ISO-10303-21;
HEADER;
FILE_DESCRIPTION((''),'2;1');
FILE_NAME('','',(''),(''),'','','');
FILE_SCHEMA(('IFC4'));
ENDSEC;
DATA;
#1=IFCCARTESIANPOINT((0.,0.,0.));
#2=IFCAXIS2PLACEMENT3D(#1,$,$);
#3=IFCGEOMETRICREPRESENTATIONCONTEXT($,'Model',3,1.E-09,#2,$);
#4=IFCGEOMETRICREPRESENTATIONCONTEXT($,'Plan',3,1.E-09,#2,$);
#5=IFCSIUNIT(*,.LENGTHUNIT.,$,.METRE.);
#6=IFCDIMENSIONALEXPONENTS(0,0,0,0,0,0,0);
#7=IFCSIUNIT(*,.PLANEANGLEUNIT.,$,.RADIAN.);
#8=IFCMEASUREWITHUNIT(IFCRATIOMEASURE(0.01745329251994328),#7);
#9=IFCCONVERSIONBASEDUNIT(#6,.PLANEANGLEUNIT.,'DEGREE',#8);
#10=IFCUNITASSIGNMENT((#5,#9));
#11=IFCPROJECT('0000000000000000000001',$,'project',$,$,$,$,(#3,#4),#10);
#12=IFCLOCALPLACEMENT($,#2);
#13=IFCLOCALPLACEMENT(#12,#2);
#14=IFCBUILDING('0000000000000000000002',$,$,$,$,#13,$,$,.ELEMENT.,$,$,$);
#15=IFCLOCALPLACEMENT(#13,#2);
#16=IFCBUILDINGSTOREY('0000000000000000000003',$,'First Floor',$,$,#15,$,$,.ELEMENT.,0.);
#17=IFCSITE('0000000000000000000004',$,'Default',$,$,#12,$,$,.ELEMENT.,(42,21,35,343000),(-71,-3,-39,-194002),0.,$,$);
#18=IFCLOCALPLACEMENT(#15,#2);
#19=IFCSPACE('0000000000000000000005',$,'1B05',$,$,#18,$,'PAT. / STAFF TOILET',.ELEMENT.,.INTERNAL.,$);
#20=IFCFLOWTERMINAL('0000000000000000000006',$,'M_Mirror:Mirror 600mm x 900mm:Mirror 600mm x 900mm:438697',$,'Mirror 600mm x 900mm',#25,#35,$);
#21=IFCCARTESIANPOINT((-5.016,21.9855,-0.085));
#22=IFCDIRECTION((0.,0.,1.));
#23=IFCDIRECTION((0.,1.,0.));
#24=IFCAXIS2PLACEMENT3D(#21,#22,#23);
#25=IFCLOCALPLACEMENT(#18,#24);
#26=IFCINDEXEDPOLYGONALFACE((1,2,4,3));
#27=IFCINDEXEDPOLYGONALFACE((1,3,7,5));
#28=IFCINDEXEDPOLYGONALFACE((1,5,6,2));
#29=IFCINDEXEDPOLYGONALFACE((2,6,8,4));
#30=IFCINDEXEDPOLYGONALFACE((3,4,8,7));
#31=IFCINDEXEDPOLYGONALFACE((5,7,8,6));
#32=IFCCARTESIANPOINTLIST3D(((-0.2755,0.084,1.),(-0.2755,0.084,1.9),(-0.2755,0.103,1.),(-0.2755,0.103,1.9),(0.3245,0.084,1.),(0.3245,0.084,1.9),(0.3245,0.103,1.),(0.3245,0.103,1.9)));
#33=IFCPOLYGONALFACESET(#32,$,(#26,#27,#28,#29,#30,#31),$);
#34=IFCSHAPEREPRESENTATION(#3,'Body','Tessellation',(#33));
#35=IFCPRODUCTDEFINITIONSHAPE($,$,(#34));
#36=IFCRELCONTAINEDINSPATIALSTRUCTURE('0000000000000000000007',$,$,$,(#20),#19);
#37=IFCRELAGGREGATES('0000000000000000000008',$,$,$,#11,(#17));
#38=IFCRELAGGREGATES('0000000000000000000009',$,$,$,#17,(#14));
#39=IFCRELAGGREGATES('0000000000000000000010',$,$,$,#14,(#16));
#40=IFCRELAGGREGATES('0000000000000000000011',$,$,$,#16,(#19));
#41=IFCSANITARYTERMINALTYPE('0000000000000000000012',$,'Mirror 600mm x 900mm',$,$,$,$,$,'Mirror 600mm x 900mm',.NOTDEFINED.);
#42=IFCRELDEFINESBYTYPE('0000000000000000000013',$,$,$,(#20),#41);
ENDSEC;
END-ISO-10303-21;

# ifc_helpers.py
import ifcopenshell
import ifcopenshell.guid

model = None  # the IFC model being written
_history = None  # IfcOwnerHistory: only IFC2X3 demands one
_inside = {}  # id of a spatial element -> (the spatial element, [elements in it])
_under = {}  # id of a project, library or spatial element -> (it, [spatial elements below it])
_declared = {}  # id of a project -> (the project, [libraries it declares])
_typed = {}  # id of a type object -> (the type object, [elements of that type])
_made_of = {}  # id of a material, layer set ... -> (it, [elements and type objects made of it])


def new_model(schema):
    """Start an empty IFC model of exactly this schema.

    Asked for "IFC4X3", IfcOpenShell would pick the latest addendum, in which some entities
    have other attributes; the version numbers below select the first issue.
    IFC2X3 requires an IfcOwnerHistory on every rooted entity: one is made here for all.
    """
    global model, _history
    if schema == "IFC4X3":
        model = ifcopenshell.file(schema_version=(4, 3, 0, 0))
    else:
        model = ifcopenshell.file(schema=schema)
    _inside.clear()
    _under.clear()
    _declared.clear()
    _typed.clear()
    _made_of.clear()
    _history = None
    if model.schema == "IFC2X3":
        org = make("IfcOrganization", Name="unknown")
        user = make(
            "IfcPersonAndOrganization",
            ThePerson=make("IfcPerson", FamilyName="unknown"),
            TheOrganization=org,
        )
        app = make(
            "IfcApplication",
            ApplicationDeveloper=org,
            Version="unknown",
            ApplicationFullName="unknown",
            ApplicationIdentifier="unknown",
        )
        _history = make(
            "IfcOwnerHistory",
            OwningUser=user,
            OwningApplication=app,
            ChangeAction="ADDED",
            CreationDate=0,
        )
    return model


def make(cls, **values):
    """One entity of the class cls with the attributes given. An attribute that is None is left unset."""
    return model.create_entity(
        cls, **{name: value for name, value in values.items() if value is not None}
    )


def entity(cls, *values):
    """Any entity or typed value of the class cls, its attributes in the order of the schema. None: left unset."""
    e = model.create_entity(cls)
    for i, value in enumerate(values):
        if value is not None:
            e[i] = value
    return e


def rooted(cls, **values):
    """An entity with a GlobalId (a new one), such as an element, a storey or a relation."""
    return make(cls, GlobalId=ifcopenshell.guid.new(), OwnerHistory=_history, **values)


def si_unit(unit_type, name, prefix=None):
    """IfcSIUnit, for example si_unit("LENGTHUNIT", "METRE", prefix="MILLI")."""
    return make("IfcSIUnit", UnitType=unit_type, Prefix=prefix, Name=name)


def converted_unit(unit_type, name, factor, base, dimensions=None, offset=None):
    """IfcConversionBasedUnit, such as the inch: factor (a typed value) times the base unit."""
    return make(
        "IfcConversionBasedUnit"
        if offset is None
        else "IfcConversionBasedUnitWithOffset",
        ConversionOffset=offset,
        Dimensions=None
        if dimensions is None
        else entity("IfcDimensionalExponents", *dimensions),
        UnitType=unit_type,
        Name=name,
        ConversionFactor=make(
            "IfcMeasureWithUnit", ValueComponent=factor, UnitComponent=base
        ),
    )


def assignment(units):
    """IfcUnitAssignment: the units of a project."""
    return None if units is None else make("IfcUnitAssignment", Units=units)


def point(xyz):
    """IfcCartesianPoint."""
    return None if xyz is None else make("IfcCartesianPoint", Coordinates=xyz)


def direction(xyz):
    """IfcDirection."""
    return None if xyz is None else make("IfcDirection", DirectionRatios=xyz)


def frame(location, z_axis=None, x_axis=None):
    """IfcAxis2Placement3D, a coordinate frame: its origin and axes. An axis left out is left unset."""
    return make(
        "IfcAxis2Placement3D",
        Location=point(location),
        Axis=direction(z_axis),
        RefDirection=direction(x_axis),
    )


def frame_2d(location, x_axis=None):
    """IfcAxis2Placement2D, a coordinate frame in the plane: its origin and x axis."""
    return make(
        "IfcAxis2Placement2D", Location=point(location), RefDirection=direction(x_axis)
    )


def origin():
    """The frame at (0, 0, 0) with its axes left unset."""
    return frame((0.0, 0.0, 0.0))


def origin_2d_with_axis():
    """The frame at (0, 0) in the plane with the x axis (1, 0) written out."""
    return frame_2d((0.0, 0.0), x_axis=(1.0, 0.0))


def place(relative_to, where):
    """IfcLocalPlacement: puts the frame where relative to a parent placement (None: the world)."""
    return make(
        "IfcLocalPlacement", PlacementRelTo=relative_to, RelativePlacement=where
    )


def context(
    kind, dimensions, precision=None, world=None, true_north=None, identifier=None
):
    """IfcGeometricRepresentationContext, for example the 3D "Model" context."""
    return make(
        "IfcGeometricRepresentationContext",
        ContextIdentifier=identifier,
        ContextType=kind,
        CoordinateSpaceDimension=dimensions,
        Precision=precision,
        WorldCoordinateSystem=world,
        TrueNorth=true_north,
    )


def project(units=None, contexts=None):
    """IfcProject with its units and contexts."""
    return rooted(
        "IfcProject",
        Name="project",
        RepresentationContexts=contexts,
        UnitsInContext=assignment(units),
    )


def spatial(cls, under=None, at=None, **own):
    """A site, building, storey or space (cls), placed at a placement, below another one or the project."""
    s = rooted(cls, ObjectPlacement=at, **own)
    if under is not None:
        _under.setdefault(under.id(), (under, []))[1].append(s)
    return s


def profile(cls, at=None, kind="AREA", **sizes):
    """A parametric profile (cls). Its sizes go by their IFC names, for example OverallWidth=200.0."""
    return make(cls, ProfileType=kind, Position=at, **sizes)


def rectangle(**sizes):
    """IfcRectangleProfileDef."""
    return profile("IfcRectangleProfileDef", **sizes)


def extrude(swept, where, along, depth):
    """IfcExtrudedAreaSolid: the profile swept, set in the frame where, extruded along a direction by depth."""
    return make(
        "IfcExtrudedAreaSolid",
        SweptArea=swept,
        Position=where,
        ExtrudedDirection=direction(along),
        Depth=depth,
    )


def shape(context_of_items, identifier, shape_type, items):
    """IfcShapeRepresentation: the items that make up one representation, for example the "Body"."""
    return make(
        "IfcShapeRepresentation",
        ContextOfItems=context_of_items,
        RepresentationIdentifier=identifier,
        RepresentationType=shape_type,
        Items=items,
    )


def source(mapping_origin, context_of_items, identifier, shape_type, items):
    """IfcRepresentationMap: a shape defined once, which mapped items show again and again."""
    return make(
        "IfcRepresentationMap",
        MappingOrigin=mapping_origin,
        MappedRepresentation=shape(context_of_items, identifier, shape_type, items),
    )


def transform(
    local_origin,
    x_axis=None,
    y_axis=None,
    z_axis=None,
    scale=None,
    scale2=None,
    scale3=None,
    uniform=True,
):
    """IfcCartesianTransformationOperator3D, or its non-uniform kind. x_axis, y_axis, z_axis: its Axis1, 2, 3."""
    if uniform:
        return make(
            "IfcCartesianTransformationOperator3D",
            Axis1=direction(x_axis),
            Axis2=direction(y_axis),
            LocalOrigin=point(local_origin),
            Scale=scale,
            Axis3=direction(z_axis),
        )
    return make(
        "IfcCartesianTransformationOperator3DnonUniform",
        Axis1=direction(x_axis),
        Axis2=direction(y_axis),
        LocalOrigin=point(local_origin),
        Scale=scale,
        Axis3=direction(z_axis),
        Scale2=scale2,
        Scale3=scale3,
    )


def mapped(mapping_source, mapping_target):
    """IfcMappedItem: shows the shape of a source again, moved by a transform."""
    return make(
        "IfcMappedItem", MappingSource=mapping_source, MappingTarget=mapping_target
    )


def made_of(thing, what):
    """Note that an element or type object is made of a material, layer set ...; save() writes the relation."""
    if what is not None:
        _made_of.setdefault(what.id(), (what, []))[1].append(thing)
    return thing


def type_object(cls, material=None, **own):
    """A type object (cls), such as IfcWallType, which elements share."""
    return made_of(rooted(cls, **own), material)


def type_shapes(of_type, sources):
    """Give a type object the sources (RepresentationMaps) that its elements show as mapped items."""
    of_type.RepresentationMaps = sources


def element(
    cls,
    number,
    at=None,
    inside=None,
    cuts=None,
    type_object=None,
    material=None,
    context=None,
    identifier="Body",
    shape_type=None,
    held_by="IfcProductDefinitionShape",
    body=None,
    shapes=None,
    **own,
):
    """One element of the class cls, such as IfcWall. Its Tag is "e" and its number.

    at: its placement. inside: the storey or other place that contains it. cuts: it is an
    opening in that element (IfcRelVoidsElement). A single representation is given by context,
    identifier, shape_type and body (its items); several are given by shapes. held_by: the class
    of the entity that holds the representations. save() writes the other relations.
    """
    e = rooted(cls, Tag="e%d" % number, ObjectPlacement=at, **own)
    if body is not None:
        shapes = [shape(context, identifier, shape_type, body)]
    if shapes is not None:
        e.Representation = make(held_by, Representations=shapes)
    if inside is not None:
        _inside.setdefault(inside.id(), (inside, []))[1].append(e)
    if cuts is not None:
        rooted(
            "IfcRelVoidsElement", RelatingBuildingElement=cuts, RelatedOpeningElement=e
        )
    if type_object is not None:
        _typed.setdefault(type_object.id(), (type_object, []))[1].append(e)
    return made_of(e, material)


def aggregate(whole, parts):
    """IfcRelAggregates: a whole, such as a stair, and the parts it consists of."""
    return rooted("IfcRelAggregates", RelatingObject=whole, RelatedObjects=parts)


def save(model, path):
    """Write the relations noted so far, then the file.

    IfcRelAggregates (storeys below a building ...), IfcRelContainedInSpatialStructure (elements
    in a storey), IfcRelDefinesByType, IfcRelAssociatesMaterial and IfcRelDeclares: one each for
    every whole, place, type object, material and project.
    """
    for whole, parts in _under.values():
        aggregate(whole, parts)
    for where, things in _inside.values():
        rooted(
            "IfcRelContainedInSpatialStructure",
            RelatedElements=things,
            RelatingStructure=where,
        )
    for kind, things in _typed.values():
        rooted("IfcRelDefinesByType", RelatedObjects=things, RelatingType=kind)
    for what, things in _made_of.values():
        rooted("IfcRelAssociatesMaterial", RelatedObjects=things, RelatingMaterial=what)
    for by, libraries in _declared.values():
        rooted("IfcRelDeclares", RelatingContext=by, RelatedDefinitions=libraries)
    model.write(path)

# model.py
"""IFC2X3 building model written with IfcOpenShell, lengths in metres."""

from ifc_helpers import new_model, entity, si_unit, converted_unit, frame, origin, origin_2d_with_axis, place, context, project, spatial, rectangle, extrude, source, transform, mapped, type_object, type_shapes, element, save


model = new_model("IFC2X3")

# Units and contexts
model_context = context("Model", 3, precision=1e-09, world=origin())
plan_context = context("Plan", 3, precision=1e-09, world=origin())
ifc_project = project(units=[si_unit("LENGTHUNIT", "METRE"), converted_unit("PLANEANGLEUNIT", "DEGREE", entity("IfcRatioMeasure", 0.01745329251994328), si_unit("PLANEANGLEUNIT", "RADIAN"), dimensions=[0, 0, 0, 0, 0, 0, 0])], contexts=[model_context, plan_context])

# Site, building, storey
site_placement = place(None, origin())
site = spatial("IfcSite", under=ifc_project, at=site_placement, Name="Default", CompositionType="ELEMENT", RefLatitude=(42, 21, 35, 343000), RefLongitude=(-71, -3, -39, -194002), RefElevation=0.0)
building_placement = place(site_placement, origin())
building = spatial("IfcBuilding", under=site, at=building_placement, CompositionType="ELEMENT")
storey_placement = place(building_placement, origin())
storey = spatial("IfcBuildingStorey", under=building, at=storey_placement, Name="First Floor", CompositionType="ELEMENT", Elevation=0.0)

# Shared definitions
space_1_placement = place(storey_placement, origin())
space_1 = spatial("IfcSpace", under=storey, at=space_1_placement, Name="1B05", LongName="PAT. / STAFF TOILET", CompositionType="ELEMENT", InteriorOrExteriorSpace="INTERNAL")

# Flow terminal
sanitary_terminal_type = type_object("IfcSanitaryTerminalType", Name="Mirror 600mm x 900mm", ElementType="Mirror 600mm x 900mm", PredefinedType="NOTDEFINED")
shared_shape_1 = source(origin(), model_context, "Body", "SweptSolid", [
    extrude(rectangle(XDim=0.0191, YDim=0.6, at=origin_2d_with_axis()), frame((0.0245, 0.0935, 1.0), z_axis=(0.0, 0.0, 1.0), x_axis=(0.0, -1.0, 0.0)), (0.0, 0.0, 1.0), 0.9),
])
type_shapes(sanitary_terminal_type, [shared_shape_1])
flow_terminal_placement = place(space_1_placement, frame((-5.016, 21.9855, -0.085), z_axis=(0.0, 0.0, 1.0), x_axis=(0.0, 1.0, 0.0)))
element("IfcFlowTerminal", 1, at=flow_terminal_placement, inside=space_1, type_object=sanitary_terminal_type, Name="M_Mirror:Mirror 600mm x 900mm:Mirror 600mm x 900mm:438697", ObjectType="Mirror 600mm x 900mm", context=model_context, shape_type="MappedRepresentation", body=[
    mapped(shared_shape_1, transform((0.0, 0.0, 0.0), scale=1.0)),
])

save(model, "model.ifc")
